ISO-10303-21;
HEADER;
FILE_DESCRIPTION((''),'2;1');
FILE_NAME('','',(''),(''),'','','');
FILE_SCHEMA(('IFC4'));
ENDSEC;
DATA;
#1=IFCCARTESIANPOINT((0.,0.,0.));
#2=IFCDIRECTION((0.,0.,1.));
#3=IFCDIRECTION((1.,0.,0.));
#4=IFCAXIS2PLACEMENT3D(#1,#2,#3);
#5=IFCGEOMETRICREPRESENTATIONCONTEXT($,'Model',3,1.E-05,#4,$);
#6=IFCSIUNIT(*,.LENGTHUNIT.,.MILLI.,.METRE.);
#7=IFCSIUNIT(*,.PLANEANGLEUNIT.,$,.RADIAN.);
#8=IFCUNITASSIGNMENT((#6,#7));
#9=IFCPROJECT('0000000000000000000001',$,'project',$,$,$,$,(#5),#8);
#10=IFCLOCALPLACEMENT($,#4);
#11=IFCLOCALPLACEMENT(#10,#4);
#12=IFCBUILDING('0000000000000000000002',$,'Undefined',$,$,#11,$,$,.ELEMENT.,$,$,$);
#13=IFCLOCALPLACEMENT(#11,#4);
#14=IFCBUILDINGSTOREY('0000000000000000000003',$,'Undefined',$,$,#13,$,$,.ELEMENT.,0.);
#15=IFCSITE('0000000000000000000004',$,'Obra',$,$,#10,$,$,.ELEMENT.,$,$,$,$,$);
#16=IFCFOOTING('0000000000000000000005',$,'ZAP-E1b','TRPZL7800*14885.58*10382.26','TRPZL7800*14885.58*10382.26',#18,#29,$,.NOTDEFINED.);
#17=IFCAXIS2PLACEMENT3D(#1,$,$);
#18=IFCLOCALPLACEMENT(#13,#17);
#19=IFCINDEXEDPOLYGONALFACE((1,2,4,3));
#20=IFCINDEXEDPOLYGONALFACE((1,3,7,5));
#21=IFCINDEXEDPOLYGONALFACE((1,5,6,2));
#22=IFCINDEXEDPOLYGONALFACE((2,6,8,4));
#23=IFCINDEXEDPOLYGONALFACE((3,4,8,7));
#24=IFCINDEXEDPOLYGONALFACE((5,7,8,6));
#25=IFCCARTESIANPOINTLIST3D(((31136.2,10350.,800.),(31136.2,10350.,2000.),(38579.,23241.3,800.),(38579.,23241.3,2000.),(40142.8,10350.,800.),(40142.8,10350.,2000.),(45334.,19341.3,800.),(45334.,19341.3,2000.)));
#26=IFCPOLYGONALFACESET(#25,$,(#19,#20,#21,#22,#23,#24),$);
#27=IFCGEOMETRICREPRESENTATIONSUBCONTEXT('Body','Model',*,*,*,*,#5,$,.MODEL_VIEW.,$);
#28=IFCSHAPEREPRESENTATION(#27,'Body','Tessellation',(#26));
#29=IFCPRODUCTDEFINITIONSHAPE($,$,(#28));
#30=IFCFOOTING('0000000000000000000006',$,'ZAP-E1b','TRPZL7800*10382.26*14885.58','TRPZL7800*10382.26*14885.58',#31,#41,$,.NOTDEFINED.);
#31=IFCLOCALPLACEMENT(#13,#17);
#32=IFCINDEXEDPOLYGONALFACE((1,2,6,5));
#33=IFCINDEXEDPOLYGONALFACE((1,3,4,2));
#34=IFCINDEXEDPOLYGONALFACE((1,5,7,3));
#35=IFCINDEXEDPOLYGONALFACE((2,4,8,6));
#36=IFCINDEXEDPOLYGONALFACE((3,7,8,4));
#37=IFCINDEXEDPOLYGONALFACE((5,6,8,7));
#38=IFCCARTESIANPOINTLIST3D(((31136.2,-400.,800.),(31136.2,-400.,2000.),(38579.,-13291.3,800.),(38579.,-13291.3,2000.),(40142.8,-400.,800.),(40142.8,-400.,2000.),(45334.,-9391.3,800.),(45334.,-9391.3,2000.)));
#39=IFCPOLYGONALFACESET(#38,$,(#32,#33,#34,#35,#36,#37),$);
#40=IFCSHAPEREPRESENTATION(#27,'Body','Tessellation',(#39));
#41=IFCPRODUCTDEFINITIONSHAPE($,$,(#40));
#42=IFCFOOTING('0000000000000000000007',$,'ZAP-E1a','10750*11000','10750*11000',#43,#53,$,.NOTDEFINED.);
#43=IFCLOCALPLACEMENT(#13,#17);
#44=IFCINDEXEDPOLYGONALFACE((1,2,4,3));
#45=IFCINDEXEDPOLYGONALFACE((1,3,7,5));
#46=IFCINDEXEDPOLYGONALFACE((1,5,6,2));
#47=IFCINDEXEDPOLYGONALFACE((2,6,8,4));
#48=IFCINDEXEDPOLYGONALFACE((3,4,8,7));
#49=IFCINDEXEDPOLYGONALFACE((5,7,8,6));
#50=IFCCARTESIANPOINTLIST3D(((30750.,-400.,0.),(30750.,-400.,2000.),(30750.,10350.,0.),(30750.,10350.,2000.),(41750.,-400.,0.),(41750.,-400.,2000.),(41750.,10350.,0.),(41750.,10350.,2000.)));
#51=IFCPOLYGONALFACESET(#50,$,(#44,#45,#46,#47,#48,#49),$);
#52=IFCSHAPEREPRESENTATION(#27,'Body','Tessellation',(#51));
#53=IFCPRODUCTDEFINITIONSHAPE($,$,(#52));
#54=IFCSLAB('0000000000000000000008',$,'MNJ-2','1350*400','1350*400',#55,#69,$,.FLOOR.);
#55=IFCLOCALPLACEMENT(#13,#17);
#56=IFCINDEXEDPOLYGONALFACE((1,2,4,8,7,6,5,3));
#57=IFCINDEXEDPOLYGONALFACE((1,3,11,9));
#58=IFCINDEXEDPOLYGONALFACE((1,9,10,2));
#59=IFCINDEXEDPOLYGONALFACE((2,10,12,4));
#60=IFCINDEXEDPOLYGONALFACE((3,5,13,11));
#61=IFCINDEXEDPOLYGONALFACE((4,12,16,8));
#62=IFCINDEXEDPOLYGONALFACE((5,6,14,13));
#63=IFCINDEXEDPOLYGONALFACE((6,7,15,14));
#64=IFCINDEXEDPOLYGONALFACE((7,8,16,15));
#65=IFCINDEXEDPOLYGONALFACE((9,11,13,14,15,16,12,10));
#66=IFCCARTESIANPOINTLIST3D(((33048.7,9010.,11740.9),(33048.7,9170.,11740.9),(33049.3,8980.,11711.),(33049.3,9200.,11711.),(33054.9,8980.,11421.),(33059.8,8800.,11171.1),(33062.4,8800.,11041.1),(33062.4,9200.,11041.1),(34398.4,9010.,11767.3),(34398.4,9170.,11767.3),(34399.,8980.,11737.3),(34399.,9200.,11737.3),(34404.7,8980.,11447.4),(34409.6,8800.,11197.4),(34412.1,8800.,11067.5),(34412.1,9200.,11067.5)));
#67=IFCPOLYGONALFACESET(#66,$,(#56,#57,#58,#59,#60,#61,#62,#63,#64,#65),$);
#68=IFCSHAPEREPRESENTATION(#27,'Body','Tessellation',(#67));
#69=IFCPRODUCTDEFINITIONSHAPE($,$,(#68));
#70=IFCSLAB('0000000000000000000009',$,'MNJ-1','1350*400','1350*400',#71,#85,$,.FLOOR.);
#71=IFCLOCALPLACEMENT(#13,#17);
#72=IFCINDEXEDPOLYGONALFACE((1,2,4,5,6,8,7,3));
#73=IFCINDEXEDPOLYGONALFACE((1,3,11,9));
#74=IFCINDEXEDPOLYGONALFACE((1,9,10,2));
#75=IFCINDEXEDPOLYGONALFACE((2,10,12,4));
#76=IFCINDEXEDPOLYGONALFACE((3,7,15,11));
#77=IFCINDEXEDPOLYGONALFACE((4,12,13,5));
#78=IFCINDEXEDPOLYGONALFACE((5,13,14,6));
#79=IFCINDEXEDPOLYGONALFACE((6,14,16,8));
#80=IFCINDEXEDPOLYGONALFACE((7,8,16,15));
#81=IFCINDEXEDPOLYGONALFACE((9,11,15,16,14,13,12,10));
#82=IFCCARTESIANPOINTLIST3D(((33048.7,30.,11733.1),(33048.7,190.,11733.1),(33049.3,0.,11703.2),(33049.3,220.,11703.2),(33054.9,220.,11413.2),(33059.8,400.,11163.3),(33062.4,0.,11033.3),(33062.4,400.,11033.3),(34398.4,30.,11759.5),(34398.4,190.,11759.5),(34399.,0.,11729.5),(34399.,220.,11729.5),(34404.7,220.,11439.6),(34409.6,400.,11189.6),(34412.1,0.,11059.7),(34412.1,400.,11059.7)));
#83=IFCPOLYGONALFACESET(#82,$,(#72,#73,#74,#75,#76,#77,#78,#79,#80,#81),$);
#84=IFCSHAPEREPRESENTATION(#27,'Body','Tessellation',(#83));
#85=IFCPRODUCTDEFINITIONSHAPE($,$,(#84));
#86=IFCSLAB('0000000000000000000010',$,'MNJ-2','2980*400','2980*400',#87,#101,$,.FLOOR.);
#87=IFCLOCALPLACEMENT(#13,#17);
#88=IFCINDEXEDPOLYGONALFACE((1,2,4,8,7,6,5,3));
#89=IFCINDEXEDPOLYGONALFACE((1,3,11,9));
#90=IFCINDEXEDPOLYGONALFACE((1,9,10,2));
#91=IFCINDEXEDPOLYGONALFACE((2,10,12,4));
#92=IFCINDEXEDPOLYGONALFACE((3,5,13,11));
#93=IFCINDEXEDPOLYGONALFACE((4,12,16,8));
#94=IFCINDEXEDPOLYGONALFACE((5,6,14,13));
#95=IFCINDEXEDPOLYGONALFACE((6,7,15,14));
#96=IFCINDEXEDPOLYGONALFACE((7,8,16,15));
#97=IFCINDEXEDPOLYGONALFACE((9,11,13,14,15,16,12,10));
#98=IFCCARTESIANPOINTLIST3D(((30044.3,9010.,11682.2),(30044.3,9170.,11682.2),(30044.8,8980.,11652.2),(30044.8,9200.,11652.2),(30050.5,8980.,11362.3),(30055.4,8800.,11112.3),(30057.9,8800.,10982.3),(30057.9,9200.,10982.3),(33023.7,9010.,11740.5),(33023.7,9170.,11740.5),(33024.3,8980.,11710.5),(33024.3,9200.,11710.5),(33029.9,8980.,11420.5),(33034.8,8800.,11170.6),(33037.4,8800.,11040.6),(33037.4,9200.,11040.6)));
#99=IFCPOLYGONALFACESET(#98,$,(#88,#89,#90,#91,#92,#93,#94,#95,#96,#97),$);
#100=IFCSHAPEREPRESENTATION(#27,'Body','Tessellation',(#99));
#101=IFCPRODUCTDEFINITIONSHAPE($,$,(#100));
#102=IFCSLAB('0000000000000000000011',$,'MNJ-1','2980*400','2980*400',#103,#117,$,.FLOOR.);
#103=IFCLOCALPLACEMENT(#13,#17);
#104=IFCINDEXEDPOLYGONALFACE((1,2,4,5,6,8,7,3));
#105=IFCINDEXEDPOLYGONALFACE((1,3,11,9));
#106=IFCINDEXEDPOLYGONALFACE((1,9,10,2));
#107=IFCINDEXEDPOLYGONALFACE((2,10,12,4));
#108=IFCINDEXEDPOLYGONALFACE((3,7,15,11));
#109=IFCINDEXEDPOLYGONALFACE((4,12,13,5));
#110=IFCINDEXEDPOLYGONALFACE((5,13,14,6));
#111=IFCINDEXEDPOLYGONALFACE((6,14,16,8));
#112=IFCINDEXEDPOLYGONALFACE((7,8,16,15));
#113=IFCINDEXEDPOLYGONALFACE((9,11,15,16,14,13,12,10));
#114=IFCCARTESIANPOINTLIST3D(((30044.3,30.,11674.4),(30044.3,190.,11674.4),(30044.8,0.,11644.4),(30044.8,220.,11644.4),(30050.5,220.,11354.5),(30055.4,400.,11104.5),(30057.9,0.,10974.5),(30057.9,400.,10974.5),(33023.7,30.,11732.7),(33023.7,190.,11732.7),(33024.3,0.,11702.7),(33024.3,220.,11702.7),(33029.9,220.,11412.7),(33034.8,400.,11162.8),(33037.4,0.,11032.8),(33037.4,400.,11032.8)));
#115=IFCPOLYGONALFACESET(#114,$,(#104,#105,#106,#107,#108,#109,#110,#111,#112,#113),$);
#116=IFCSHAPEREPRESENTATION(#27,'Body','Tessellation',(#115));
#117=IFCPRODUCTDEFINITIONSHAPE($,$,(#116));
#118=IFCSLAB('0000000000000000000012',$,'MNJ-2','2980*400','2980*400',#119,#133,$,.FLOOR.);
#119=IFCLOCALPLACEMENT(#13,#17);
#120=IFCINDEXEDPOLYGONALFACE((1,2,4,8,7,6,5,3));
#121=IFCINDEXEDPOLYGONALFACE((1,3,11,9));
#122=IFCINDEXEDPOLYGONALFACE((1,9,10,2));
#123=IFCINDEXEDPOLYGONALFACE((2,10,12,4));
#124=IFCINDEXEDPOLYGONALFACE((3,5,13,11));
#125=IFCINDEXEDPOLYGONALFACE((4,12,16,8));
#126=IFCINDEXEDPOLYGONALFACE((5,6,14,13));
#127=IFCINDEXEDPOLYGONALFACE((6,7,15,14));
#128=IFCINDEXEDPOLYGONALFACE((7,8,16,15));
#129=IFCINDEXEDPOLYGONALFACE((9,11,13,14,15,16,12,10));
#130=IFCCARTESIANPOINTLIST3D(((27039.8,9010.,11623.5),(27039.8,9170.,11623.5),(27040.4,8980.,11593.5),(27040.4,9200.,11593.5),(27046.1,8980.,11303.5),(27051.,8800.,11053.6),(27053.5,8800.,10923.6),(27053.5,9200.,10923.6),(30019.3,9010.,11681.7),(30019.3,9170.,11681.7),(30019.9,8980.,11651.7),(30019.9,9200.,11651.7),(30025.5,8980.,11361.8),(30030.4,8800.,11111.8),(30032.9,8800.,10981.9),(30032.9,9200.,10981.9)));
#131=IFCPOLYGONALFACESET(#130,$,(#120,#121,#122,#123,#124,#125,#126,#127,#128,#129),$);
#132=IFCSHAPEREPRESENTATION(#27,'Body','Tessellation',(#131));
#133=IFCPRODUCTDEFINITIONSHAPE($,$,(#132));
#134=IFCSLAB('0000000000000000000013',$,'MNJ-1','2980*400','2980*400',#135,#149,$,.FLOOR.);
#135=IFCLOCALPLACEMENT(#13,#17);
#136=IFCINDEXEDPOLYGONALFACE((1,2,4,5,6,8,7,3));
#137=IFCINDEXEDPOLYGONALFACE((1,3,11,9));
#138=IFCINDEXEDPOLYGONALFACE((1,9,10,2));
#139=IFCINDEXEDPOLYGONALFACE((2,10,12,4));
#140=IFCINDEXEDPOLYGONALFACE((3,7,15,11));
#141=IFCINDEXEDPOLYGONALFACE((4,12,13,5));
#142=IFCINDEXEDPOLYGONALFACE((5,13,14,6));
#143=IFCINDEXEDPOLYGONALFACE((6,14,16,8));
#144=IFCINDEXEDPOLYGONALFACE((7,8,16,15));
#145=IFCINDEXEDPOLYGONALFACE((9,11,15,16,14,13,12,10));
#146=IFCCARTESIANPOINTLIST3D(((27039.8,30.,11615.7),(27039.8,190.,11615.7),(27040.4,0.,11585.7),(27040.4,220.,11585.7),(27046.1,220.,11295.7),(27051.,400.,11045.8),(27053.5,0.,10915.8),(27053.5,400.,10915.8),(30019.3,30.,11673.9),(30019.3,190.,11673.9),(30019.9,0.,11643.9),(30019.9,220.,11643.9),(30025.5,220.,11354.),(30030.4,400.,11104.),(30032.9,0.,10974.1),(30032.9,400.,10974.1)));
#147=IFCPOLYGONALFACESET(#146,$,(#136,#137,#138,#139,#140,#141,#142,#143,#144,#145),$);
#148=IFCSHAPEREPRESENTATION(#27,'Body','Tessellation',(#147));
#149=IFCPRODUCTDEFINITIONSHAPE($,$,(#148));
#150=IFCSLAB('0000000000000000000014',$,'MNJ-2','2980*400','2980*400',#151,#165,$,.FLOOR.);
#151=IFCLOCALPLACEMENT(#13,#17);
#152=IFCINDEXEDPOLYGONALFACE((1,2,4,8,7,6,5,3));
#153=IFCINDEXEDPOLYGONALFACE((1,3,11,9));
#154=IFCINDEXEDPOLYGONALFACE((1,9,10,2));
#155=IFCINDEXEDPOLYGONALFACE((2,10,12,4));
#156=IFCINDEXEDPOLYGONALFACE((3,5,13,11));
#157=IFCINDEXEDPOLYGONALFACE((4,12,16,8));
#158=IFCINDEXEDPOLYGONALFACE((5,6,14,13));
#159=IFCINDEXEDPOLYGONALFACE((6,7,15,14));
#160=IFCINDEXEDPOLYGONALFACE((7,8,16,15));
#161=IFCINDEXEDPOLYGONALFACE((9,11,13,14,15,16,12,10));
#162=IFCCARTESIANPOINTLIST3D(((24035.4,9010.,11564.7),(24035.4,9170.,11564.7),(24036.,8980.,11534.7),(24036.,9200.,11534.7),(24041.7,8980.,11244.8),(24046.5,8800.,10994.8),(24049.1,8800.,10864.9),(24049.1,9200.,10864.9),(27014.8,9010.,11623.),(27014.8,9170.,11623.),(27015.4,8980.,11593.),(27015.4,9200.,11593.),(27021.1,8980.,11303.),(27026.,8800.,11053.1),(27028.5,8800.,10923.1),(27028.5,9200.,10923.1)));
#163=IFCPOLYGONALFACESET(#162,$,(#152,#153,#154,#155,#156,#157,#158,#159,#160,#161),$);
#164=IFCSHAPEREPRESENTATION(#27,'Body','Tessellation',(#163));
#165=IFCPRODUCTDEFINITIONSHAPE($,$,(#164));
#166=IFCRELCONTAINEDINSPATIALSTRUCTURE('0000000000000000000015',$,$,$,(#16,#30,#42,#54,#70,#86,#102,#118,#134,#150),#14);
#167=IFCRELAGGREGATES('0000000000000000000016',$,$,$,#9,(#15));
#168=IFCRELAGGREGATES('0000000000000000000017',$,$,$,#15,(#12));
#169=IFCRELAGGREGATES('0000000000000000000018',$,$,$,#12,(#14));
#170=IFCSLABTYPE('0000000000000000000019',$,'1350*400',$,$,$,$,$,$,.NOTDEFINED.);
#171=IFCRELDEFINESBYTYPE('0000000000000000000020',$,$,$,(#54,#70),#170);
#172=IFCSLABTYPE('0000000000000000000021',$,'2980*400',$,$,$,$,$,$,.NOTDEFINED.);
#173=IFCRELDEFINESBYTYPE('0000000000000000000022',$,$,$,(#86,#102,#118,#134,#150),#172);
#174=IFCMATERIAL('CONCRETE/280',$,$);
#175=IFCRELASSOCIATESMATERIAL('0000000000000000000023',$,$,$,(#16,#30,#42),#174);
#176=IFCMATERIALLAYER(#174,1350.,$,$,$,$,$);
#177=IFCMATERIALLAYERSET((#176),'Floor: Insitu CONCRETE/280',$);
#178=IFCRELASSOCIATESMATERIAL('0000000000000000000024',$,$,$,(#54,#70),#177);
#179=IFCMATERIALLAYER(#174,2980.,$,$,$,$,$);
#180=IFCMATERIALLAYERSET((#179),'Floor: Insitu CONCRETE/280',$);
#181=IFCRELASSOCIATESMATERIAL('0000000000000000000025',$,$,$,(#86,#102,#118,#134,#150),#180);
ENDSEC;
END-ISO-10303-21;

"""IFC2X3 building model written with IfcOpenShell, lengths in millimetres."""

from ifc_helpers import new_model, si_unit, frame, origin_with_axes, origin_2d_with_axis, place, context, subcontext, project, spatial, polyline, rectangle, outline, extrude, material, layer, layer_set, layer_usage, type_object, element, save


model = new_model("IFC2X3")

# Units and contexts
model_context = context("Model", 3, precision=1e-05, world=origin_with_axes())
body_context = subcontext(model_context, "Body", "Model", "MODEL_VIEW")
ifc_project = project(units=[si_unit("LENGTHUNIT", "METRE", prefix="MILLI"), si_unit("PLANEANGLEUNIT", "RADIAN")], contexts=[model_context])

# Site, building, storey
site_placement = place(None, origin_with_axes())
site = spatial("IfcSite", under=ifc_project, at=site_placement, Name="Obra", CompositionType="ELEMENT")
building_placement = place(site_placement, origin_with_axes())
building = spatial("IfcBuilding", under=site, at=building_placement, Name="Undefined", CompositionType="ELEMENT")
storey_placement = place(building_placement, origin_with_axes())
storey = spatial("IfcBuildingStorey", under=building, at=storey_placement, Name="Undefined", CompositionType="ELEMENT", Elevation=0.0)

# Footings
ifc_material_1 = material(Name="CONCRETE/280")
footing_1_placement = place(storey_placement, frame((38235.1, 14845.6, 800.0), z_axis=(-0.866025, 0.5, 0.0), x_axis=(0.0, 0.0, 1.0)))
element("IfcFooting", 1, at=footing_1_placement, inside=storey, material=ifc_material_1, Name="ZAP-E1b", Description="TRPZL7800*14885.58*10382.26", ObjectType="TRPZL7800*14885.58*10382.26", PredefinedType="NOTDEFINED", context=body_context, shape_type="SweptSolid", body=[
    extrude(outline(polyline([(-7442.8, -3900.0), (-7442.8, 3900.0), (7442.8, 3900.0), (2939.5, -3900.0), (-7442.8, -3900.0)])), frame((1200.0, 0.0, 0.0), z_axis=(-1.0, 0.0, 0.0), x_axis=(0.0, -1.0, 0.0)), (0.0, 0.0, 1.0), 1200.0),
])
footing_2_placement = place(storey_placement, frame((39360.9, -6845.6, 800.0), z_axis=(0.866025, 0.5, 0.0), x_axis=(0.0, 0.0, 1.0)))
element("IfcFooting", 2, at=footing_2_placement, inside=storey, material=ifc_material_1, Name="ZAP-E1b", Description="TRPZL7800*10382.26*14885.58", ObjectType="TRPZL7800*10382.26*14885.58", PredefinedType="NOTDEFINED", context=body_context, shape_type="SweptSolid", body=[
    extrude(outline(polyline([(-5191.1, 3900.0), (5191.1, 3900.0), (9694.4, -3900.0), (-5191.1, -3900.0), (-5191.1, 3900.0)])), frame((1200.0, 0.0, 0.0), z_axis=(-1.0, 0.0, 0.0), x_axis=(0.0, -1.0, 0.0)), (0.0, 0.0, 1.0), 1200.0),
])
footing_3_placement = place(storey_placement, frame((36250.0, 4975.0, 0.0), z_axis=(0.0, 1.0, 0.0), x_axis=(0.0, 0.0, 1.0)))
element("IfcFooting", 3, at=footing_3_placement, inside=storey, material=ifc_material_1, Name="ZAP-E1a", Description="10750*11000", ObjectType="10750*11000", PredefinedType="NOTDEFINED", context=body_context, shape_type="SweptSolid", body=[
    extrude(rectangle(XDim=11000.0, YDim=10750.0, at=origin_2d_with_axis()), frame((2000.0, 0.0, 0.0), z_axis=(-1.0, 0.0, 0.0), x_axis=(0.0, -1.0, 0.0)), (0.0, 0.0, 1.0), 2000.0),
])

# Slabs
ifc_layer_1 = layer(ifc_material_1, 1350.0)
ifc_layer_set_1 = layer_set([ifc_layer_1], Name="Floor: Insitu CONCRETE/280")
ifc_layer_usage_1 = layer_usage(ifc_layer_set_1, "AXIS3", "POSITIVE", -675.0)
slab_type_1 = type_object("IfcSlabType", Name="1350*400", PredefinedType="NOTDEFINED")
slab_1_placement = place(storey_placement, frame((33724.1, 9200.0, 11724.1), z_axis=(-0.999809, 0.0, -0.019547), x_axis=(0.019547, 0.0, -0.999809)))
element("IfcSlab", 4, at=slab_1_placement, inside=storey, type_object=slab_type_1, material=ifc_layer_usage_1, Name="MNJ-2", Description="1350*400", ObjectType="1350*400", PredefinedType="FLOOR", context=body_context, shape_type="SweptSolid", body=[
    extrude(outline(polyline([(0.0, 0.0), (670.0, 0.0), (670.0, 400.0), (540.0, 400.0), (290.0, 220.0), (0.0, 220.0), (-30.0, 190.0), (-30.0, 30.0), (0.0, 0.0)])), frame((0.0, 0.0, -675.0), z_axis=(0.0, 0.0, 1.0), x_axis=(1.0, 0.0, 0.0)), (0.0, 0.0, 1.0), 1350.0),
])
ifc_layer_usage_2 = layer_usage(ifc_layer_set_1, "AXIS3", "POSITIVE", -675.0)
slab_2_placement = place(storey_placement, frame((33724.1, 0.0, 11716.3), z_axis=(0.999809, 0.0, 0.019547), x_axis=(0.019547, 0.0, -0.999809)))
element("IfcSlab", 5, at=slab_2_placement, inside=storey, type_object=slab_type_1, material=ifc_layer_usage_2, Name="MNJ-1", Description="1350*400", ObjectType="1350*400", PredefinedType="FLOOR", context=body_context, shape_type="SweptSolid", body=[
    extrude(outline(polyline([(0.0, 0.0), (670.0, 0.0), (670.0, 400.0), (540.0, 400.0), (290.0, 220.0), (0.0, 220.0), (-30.0, 190.0), (-30.0, 30.0), (0.0, 0.0)])), frame((0.0, 0.0, -675.0), z_axis=(0.0, 0.0, 1.0), x_axis=(1.0, 0.0, 0.0)), (0.0, 0.0, 1.0), 1350.0),
])
ifc_layer_2 = layer(ifc_material_1, 2980.0)
ifc_layer_set_2 = layer_set([ifc_layer_2], Name="Floor: Insitu CONCRETE/280")
ifc_layer_usage_3 = layer_usage(ifc_layer_set_2, "AXIS3", "POSITIVE", -1490.0)
slab_type_2 = type_object("IfcSlabType", Name="2980*400", PredefinedType="NOTDEFINED")
slab_3_placement = place(storey_placement, frame((31534.6, 9200.0, 11681.3), z_axis=(-0.999809, 0.0, -0.019547), x_axis=(0.019547, 0.0, -0.999809)))
element("IfcSlab", 6, at=slab_3_placement, inside=storey, type_object=slab_type_2, material=ifc_layer_usage_3, Name="MNJ-2", Description="2980*400", ObjectType="2980*400", PredefinedType="FLOOR", context=body_context, shape_type="SweptSolid", body=[
    extrude(outline(polyline([(0.0, 0.0), (670.0, 0.0), (670.0, 400.0), (540.0, 400.0), (290.0, 220.0), (0.0, 220.0), (-30.0, 190.0), (-30.0, 30.0), (0.0, 0.0)])), frame((0.0, 0.0, -1490.0), z_axis=(0.0, 0.0, 1.0), x_axis=(1.0, 0.0, 0.0)), (0.0, 0.0, 1.0), 2980.0),
])
ifc_layer_usage_4 = layer_usage(ifc_layer_set_2, "AXIS3", "POSITIVE", -1490.0)
slab_4_placement = place(storey_placement, frame((31534.6, 0.0, 11673.5), z_axis=(0.999809, 0.0, 0.019547), x_axis=(0.019547, 0.0, -0.999809)))
element("IfcSlab", 7, at=slab_4_placement, inside=storey, type_object=slab_type_2, material=ifc_layer_usage_4, Name="MNJ-1", Description="2980*400", ObjectType="2980*400", PredefinedType="FLOOR", context=body_context, shape_type="SweptSolid", body=[
    extrude(outline(polyline([(0.0, 0.0), (670.0, 0.0), (670.0, 400.0), (540.0, 400.0), (290.0, 220.0), (0.0, 220.0), (-30.0, 190.0), (-30.0, 30.0), (0.0, 0.0)])), frame((0.0, 0.0, -1490.0), z_axis=(0.0, 0.0, 1.0), x_axis=(1.0, 0.0, 0.0)), (0.0, 0.0, 1.0), 2980.0),
])
ifc_layer_usage_5 = layer_usage(ifc_layer_set_2, "AXIS3", "POSITIVE", -1490.0)
slab_5_placement = place(storey_placement, frame((28530.1, 9200.0, 11622.6), z_axis=(-0.999809, 0.0, -0.019547), x_axis=(0.019547, 0.0, -0.999809)))
element("IfcSlab", 8, at=slab_5_placement, inside=storey, type_object=slab_type_2, material=ifc_layer_usage_5, Name="MNJ-2", Description="2980*400", ObjectType="2980*400", PredefinedType="FLOOR", context=body_context, shape_type="SweptSolid", body=[
    extrude(outline(polyline([(0.0, 0.0), (670.0, 0.0), (670.0, 400.0), (540.0, 400.0), (290.0, 220.0), (0.0, 220.0), (-30.0, 190.0), (-30.0, 30.0), (0.0, 0.0)])), frame((0.0, 0.0, -1490.0), z_axis=(0.0, 0.0, 1.0), x_axis=(1.0, 0.0, 0.0)), (0.0, 0.0, 1.0), 2980.0),
])
ifc_layer_usage_6 = layer_usage(ifc_layer_set_2, "AXIS3", "POSITIVE", -1490.0)
slab_6_placement = place(storey_placement, frame((28530.1, 0.0, 11614.8), z_axis=(0.999809, 0.0, 0.019547), x_axis=(0.019547, 0.0, -0.999809)))
element("IfcSlab", 9, at=slab_6_placement, inside=storey, type_object=slab_type_2, material=ifc_layer_usage_6, Name="MNJ-1", Description="2980*400", ObjectType="2980*400", PredefinedType="FLOOR", context=body_context, shape_type="SweptSolid", body=[
    extrude(outline(polyline([(0.0, 0.0), (670.0, 0.0), (670.0, 400.0), (540.0, 400.0), (290.0, 220.0), (0.0, 220.0), (-30.0, 190.0), (-30.0, 30.0), (0.0, 0.0)])), frame((0.0, 0.0, -1490.0), z_axis=(0.0, 0.0, 1.0), x_axis=(1.0, 0.0, 0.0)), (0.0, 0.0, 1.0), 2980.0),
])
ifc_layer_usage_7 = layer_usage(ifc_layer_set_2, "AXIS3", "POSITIVE", -1490.0)
slab_7_placement = place(storey_placement, frame((25525.7, 9200.0, 11563.9), z_axis=(-0.999809, 0.0, -0.019547), x_axis=(0.019547, 0.0, -0.999809)))
element("IfcSlab", 10, at=slab_7_placement, inside=storey, type_object=slab_type_2, material=ifc_layer_usage_7, Name="MNJ-2", Description="2980*400", ObjectType="2980*400", PredefinedType="FLOOR", context=body_context, shape_type="SweptSolid", body=[
    extrude(outline(polyline([(0.0, 0.0), (670.0, 0.0), (670.0, 400.0), (540.0, 400.0), (290.0, 220.0), (0.0, 220.0), (-30.0, 190.0), (-30.0, 30.0), (0.0, 0.0)])), frame((0.0, 0.0, -1490.0), z_axis=(0.0, 0.0, 1.0), x_axis=(1.0, 0.0, 0.0)), (0.0, 0.0, 1.0), 2980.0),
])

save(model, "model.ifc")
